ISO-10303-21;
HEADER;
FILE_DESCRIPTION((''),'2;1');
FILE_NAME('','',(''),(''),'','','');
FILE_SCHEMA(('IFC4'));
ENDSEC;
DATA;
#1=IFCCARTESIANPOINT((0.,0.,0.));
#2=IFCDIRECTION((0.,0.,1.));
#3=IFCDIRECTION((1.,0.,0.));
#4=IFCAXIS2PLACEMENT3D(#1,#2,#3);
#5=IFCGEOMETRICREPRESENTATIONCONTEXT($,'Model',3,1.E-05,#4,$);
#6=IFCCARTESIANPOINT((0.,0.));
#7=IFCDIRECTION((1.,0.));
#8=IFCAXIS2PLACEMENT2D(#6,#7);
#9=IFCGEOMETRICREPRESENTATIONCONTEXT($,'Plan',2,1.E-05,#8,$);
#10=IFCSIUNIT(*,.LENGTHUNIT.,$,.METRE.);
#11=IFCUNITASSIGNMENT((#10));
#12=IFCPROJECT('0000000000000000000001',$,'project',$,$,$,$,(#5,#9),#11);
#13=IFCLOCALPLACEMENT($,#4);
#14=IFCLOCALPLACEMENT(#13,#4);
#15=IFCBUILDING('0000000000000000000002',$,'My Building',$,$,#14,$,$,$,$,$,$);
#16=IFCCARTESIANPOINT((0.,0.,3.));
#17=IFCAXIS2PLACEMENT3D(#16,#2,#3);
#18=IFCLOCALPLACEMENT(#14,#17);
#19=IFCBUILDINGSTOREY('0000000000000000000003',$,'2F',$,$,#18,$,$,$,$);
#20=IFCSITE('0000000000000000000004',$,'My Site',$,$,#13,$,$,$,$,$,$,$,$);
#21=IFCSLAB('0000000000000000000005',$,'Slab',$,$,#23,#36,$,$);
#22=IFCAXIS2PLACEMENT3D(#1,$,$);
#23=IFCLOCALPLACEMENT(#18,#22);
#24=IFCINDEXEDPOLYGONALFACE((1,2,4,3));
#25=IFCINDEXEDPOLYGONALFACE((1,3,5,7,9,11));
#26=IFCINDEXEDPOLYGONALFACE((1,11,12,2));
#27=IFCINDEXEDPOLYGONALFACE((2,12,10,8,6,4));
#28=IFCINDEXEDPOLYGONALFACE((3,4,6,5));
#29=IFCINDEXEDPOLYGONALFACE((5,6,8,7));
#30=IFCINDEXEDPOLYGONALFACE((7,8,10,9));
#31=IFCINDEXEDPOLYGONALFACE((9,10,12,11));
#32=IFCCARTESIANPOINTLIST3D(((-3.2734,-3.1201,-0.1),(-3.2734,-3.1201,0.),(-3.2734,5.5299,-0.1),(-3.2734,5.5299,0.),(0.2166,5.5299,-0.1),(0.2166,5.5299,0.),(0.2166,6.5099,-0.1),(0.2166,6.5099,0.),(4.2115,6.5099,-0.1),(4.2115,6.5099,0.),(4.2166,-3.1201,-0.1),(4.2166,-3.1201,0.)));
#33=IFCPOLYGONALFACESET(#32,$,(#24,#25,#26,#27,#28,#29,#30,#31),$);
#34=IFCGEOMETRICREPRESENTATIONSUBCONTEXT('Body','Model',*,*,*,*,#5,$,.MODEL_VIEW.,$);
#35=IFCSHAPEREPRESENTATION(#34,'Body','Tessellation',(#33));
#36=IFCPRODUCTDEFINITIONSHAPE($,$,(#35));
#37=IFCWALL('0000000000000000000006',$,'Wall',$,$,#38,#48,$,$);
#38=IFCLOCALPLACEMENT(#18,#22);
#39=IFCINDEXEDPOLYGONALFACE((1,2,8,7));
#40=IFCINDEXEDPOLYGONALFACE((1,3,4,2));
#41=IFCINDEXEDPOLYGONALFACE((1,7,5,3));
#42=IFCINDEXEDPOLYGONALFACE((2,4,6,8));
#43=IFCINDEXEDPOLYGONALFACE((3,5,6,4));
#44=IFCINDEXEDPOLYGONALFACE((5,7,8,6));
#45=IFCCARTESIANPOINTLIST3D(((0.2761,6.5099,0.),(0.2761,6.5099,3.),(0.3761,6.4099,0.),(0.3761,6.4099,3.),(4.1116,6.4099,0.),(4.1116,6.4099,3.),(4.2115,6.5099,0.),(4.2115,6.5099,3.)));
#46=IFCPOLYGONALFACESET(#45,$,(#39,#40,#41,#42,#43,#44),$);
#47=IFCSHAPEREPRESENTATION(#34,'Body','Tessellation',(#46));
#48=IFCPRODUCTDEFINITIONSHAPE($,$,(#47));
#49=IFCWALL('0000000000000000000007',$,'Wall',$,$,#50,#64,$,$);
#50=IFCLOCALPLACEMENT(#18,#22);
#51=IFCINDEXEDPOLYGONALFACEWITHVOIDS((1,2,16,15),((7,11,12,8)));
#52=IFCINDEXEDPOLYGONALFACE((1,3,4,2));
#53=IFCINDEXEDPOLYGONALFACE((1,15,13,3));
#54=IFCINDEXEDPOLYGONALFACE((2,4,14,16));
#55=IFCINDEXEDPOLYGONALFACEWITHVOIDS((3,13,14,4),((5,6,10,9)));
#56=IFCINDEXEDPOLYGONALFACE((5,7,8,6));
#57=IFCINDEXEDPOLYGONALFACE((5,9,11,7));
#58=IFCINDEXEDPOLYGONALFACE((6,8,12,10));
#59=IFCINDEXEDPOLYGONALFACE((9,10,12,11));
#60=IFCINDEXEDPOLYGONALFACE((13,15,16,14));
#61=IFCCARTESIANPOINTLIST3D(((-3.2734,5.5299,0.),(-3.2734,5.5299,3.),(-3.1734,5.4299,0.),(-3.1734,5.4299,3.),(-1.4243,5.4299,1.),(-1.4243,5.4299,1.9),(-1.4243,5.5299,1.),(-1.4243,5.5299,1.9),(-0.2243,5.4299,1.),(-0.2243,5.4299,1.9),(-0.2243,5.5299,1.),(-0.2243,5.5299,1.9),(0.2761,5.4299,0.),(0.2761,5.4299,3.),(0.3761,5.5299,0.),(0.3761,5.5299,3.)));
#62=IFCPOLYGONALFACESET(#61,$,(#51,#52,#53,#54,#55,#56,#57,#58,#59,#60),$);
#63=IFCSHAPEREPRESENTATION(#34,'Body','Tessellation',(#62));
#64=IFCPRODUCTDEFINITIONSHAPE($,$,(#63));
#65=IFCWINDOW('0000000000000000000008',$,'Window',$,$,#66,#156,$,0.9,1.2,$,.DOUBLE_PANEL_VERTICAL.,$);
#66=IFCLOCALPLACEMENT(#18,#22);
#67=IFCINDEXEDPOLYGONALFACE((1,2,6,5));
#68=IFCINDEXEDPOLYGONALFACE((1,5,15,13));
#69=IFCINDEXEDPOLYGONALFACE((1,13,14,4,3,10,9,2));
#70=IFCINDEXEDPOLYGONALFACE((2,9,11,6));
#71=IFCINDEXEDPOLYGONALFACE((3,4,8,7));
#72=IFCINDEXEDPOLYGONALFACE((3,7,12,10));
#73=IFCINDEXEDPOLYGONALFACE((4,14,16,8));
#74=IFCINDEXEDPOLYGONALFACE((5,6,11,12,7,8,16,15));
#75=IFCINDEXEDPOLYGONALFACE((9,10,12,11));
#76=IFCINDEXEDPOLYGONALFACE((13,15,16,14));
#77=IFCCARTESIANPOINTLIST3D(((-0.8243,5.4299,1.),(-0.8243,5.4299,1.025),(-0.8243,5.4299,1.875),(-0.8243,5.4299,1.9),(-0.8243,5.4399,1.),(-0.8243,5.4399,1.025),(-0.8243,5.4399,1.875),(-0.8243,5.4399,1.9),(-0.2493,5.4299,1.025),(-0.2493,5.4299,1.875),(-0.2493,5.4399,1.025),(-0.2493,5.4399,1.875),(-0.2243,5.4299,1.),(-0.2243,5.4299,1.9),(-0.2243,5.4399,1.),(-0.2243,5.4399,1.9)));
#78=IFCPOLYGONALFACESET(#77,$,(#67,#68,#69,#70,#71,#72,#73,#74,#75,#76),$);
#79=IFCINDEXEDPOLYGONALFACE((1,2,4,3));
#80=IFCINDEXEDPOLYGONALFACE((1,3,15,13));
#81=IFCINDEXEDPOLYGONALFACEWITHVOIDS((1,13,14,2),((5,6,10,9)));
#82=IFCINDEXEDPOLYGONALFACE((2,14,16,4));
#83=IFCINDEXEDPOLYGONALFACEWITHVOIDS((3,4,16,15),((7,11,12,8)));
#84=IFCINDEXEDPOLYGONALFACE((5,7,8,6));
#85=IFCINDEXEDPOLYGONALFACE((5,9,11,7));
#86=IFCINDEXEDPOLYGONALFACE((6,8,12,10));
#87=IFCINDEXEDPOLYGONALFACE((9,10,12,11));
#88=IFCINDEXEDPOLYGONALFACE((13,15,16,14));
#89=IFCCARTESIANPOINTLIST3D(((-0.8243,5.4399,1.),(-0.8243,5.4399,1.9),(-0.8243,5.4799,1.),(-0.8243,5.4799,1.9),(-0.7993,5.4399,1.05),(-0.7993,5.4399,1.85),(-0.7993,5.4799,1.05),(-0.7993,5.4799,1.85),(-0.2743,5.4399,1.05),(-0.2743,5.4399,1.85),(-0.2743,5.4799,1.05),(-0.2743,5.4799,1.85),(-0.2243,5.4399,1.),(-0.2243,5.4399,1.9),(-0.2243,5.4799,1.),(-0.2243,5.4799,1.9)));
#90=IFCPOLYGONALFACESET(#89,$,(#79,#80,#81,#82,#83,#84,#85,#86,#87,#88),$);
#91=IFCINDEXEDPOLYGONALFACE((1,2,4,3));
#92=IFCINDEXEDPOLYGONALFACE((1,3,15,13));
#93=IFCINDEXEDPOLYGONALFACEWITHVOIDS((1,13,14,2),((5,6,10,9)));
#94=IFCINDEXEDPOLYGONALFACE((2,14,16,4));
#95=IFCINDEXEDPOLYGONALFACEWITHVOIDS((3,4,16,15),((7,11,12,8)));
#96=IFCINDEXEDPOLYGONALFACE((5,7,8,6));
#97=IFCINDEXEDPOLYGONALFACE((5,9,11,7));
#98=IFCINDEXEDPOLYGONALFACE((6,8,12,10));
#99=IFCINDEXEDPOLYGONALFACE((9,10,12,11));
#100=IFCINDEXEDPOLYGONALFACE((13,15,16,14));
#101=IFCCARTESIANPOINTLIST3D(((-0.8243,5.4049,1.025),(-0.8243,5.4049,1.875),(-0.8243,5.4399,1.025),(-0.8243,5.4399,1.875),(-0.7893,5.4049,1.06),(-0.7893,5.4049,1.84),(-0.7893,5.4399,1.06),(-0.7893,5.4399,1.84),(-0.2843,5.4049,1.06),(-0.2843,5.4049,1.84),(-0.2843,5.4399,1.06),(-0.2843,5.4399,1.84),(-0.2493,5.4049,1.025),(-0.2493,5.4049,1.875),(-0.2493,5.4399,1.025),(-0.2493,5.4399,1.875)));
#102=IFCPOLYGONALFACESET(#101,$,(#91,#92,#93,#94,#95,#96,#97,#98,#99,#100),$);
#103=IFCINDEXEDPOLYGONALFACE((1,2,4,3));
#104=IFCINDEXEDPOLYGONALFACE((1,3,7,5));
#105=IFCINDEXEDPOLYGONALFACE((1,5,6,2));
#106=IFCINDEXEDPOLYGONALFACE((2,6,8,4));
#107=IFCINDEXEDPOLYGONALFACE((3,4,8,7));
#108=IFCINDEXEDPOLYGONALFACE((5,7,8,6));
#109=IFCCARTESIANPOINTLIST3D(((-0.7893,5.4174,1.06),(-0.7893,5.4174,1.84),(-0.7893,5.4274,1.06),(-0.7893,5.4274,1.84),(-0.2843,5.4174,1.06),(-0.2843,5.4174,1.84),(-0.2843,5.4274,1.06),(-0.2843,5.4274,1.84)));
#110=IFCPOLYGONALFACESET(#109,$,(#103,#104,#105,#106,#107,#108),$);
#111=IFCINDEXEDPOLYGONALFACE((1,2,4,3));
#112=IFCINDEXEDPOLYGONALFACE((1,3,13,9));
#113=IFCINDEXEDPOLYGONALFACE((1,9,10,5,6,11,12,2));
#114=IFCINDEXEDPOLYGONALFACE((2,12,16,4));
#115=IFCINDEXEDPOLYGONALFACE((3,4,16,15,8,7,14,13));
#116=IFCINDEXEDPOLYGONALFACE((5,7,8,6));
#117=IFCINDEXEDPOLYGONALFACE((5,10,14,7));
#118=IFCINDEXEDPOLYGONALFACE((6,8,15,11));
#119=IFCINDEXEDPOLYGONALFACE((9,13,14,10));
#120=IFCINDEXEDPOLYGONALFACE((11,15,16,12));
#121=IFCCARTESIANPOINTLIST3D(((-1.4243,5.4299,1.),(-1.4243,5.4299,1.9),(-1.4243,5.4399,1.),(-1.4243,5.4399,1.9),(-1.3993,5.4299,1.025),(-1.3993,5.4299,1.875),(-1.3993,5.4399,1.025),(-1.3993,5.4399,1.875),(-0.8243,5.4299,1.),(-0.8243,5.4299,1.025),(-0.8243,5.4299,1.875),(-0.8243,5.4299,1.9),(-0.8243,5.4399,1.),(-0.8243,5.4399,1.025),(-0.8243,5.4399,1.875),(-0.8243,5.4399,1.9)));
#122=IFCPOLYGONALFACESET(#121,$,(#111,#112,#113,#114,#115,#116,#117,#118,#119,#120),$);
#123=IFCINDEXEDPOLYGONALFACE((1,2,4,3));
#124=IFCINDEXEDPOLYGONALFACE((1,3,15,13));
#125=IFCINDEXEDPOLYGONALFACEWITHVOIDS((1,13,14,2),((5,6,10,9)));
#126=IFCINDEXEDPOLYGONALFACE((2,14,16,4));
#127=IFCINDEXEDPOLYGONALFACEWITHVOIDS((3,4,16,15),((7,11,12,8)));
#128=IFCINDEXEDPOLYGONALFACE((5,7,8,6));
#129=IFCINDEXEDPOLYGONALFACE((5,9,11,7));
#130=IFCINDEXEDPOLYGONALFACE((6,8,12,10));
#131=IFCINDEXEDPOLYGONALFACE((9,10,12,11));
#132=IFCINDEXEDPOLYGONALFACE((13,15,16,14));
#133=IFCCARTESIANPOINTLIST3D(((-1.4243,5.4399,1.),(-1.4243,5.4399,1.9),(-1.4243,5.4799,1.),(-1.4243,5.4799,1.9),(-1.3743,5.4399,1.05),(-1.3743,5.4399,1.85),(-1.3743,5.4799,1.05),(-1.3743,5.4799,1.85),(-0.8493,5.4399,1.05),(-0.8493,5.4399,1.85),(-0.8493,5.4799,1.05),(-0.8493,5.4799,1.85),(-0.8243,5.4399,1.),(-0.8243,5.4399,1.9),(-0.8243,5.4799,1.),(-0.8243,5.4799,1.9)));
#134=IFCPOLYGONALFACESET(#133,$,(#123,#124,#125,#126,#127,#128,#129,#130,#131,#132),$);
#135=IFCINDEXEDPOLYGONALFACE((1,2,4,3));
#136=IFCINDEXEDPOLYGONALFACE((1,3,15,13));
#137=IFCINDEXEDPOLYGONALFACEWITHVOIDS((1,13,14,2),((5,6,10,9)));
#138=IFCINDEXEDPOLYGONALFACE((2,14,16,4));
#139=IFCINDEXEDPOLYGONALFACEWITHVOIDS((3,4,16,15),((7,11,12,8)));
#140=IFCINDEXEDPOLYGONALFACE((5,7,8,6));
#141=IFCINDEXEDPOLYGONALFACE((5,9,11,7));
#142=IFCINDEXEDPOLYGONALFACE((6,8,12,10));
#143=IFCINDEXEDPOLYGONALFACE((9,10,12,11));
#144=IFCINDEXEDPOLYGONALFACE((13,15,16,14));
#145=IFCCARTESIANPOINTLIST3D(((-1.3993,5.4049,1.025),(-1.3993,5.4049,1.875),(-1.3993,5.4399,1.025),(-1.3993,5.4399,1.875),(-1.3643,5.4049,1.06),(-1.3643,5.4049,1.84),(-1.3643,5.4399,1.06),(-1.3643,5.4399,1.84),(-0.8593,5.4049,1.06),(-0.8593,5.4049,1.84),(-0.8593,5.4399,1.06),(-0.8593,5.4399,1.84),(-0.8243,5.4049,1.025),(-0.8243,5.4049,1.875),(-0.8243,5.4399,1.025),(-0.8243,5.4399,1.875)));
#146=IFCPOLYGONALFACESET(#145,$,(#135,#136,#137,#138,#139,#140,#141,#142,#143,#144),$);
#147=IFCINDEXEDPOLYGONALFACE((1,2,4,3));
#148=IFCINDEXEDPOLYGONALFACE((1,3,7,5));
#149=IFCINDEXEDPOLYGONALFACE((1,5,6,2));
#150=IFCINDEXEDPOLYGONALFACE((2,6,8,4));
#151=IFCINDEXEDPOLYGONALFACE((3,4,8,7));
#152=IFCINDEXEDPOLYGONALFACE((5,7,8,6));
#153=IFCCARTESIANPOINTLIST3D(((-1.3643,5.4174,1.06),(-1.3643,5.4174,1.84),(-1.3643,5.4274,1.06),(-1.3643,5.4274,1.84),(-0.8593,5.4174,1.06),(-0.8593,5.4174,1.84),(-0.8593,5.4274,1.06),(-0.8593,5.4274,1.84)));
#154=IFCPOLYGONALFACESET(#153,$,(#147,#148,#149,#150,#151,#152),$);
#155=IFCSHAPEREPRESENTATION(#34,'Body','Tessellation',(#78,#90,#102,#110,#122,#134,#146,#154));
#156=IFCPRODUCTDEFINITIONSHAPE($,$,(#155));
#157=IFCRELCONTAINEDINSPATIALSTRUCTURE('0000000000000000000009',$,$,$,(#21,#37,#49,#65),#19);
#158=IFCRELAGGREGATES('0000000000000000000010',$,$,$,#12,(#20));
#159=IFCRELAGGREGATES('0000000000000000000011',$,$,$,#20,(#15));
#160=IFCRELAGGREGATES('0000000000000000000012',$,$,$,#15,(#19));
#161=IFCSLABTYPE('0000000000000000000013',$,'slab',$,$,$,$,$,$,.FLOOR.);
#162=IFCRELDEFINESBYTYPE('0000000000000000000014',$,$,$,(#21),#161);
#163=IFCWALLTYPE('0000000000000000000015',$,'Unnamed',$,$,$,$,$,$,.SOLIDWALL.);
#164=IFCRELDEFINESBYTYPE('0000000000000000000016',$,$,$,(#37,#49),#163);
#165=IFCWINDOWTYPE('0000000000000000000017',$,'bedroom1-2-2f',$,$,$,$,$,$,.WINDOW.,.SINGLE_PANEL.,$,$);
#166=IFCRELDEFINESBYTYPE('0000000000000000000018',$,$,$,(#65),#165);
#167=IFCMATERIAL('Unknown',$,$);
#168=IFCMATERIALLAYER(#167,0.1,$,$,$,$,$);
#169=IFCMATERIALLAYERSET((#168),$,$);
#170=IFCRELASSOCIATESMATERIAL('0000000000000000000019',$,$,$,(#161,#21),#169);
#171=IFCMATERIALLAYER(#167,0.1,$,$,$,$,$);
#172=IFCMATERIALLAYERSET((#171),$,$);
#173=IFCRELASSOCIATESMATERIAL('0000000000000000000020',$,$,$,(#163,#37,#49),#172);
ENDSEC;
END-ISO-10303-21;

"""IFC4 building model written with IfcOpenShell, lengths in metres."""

from ifc_helpers import new_model, entity, si_unit, frame, origin_with_axes, origin_2d_with_axis, place, context, subcontext, project, spatial, line, indexed_curve, outline, extrude, shape, source, transform, mapped, material, layer, layer_set, layer_usage, type_object, type_shapes, element, fill, save


model = new_model("IFC4")

# Units and contexts
model_context = context("Model", 3, precision=1e-05, world=origin_with_axes())
plan_context = context("Plan", 2, precision=1e-05, world=origin_2d_with_axis())
body_context_1 = subcontext(model_context, "Body", "Model", "MODEL_VIEW")
body_context_2 = subcontext(plan_context, "Body", "Plan", "PLAN_VIEW")
ifc_project = project(units=[si_unit("LENGTHUNIT", "METRE")], contexts=[model_context, plan_context])

# Site, building, storey
site_placement = place(None, origin_with_axes())
site = spatial("IfcSite", under=ifc_project, at=site_placement, Name="My Site")
building_placement = place(site_placement, origin_with_axes())
building = spatial("IfcBuilding", under=site, at=building_placement, Name="My Building")
storey_placement = place(building_placement, frame((0.0, 0.0, 3.0), z_axis=(0.0, 0.0, 1.0), x_axis=(1.0, 0.0, 0.0)))
storey = spatial("IfcBuildingStorey", under=building, at=storey_placement, Name="2F")

# Slab
ifc_material = material(Name="Unknown")
ifc_layer_1 = layer(ifc_material, 0.1)
ifc_layer_set_1 = layer_set([ifc_layer_1])
ifc_layer_usage_1 = layer_usage(ifc_layer_set_1, "AXIS3", "POSITIVE", -0.1)
slab_type = type_object("IfcSlabType", Name="slab", PredefinedType="FLOOR", material=ifc_layer_set_1)
slab_placement = place(storey_placement, frame((4.2115, 6.5099, 0.0), z_axis=(0.0, 0.0, 1.0), x_axis=(1.0, 0.0, 0.0)))
element("IfcSlab", 1, at=slab_placement, inside=storey, type_object=slab_type, material=ifc_layer_usage_1, Name="Slab", context=body_context_1, shape_type="SweptSolid", body=[
    extrude(outline(indexed_curve([(0.0, 0.0), (-3.9949, 0.0), (-3.9949, -0.98), (-7.4849, -0.98), (-7.4849, -9.63), (0.0051, -9.63), (0.0, 0.0)])), frame((0.0, 0.0, -0.1), z_axis=(0.0, 0.0, 1.0), x_axis=(1.0, 0.0, 0.0)), (0.0, 0.0, 1.0), 0.1),
])

# Wall
ifc_layer_2 = layer(ifc_material, 0.1)
ifc_layer_set_2 = layer_set([ifc_layer_2])
ifc_layer_usage_2 = layer_usage(ifc_layer_set_2, "AXIS2", "POSITIVE", 0.0)
wall_type = type_object("IfcWallType", Name="Unnamed", PredefinedType="SOLIDWALL", material=ifc_layer_set_2)
wall_1_placement = place(storey_placement, frame((4.2115, 6.5099, 0.0), z_axis=(0.0, 0.0, 1.0), x_axis=(-1.0, 0.0, 0.0)))
element("IfcWall", 2, at=wall_1_placement, inside=storey, type_object=wall_type, material=ifc_layer_usage_2, Name="Wall", context=body_context_1, shape_type="SweptSolid", body=[
    extrude(outline(indexed_curve([(0.0, 0.0), (0.1, 0.1), (3.8355, 0.1), (3.9355, 0.0)], segments=[line(1, 2, 3, 4, 1)])), origin_with_axes(), (0.0, 0.0, 1.0), 3.0),
])

# Wall, opening, window
ifc_layer_usage_3 = layer_usage(ifc_layer_set_2, "AXIS2", "POSITIVE", 0.0)
wall_2_placement = place(storey_placement, frame((0.3761, 5.5299, 0.0), z_axis=(0.0, 0.0, 1.0), x_axis=(-1.0, 0.0, 0.0)))
wall_2 = element("IfcWall", 3, at=wall_2_placement, inside=storey, type_object=wall_type, material=ifc_layer_usage_3, Name="Wall", context=body_context_1, shape_type="SweptSolid", body=[
    extrude(outline(indexed_curve([(0.0, 0.0), (0.1, 0.1), (3.5495, 0.1), (3.6495, 0.0)], segments=[line(1, 2, 3, 4, 1)])), origin_with_axes(), (0.0, 0.0, 1.0), 3.0),
])
shared_shape_1 = source(origin_with_axes(), body_context_1, "Body", "SweptSolid", [
    extrude(outline(indexed_curve([(0.0, 0.0), (1.2, 0.0), (1.2, 0.9), (0.0, 0.9)], segments=[line(1, 2, 3, 4, 1)])), frame((0.0, -0.6, 0.0), z_axis=(0.0, -1.0, 0.0), x_axis=(1.0, 0.0, 0.0)), (0.0, 0.0, -1.0), 1.2),
])
opening_1_placement = place(wall_2_placement, frame((0.6003, 0.0, 1.0), z_axis=(0.0, 0.0, 1.0), x_axis=(1.0, 0.0, 0.0)))
opening_1 = element("IfcOpeningElement", 4, at=opening_1_placement, cuts=wall_2, PredefinedType="OPENING", context=body_context_1, shape_type="MappedRepresentation", body=[
    mapped(shared_shape_1, transform((0.0, 0.0, 0.0), x_axis=(1.0, 0.0, 0.0), y_axis=(0.0, 1.0, 0.0), z_axis=(0.0, 0.0, 1.0), scale=1.0)),
])
window_type_1 = type_object("IfcWindowType", Name="bedroom1-2-2f", PartitioningType="SINGLE_PANEL", PredefinedType="WINDOW")
shared_shape_2 = source(origin_with_axes(), body_context_1, "Body", "SweptSolid", [
    extrude(outline(indexed_curve([(0.6, 0.0), (0.0, 0.0), (0.0, 0.9), (0.6, 0.9), (0.6, 0.875), (0.025, 0.875), (0.025, 0.025), (0.6, 0.025)], segments=[line(1, 2, 3, 4, 5, 6, 7, 8, 1)])), frame((0.0, 0.09, 0.0), z_axis=(0.0, -1.0, 0.0), x_axis=(1.0, 0.0, 0.0)), (0.0, 0.0, -1.0), 0.01),
    extrude(outline(indexed_curve([(0.0, 0.0), (0.6, 0.0), (0.6, 0.9), (0.0, 0.9)], segments=[line(1, 2, 3, 4, 1)]), holes=[indexed_curve([(0.05, 0.05), (0.575, 0.05), (0.575, 0.85), (0.05, 0.85)], segments=[line(1, 2, 3, 4, 1)])]), frame((0.0, 0.05, 0.0), z_axis=(0.0, -1.0, 0.0), x_axis=(1.0, 0.0, 0.0)), (0.0, 0.0, -1.0), 0.04),
    extrude(outline(indexed_curve([(0.0, 0.0), (0.575, 0.0), (0.575, 0.85), (0.0, 0.85)], segments=[line(1, 2, 3, 4, 1)]), holes=[indexed_curve([(0.035, 0.035), (0.54, 0.035), (0.54, 0.815), (0.035, 0.815)], segments=[line(1, 2, 3, 4, 1)])]), frame((0.025, 0.09, 0.025), z_axis=(0.0, -1.0, 0.0), x_axis=(1.0, 0.0, 0.0)), (0.0, 0.0, -1.0), 0.035),
    extrude(outline(indexed_curve([(0.035, 0.035), (0.54, 0.035), (0.54, 0.815), (0.035, 0.815)], segments=[line(1, 2, 3, 4, 1)])), frame((0.025, 0.1025, 0.025), z_axis=(0.0, -1.0, 0.0), x_axis=(1.0, 0.0, 0.0)), (0.0, 0.0, -1.0), 0.01),
    extrude(outline(indexed_curve([(0.0, 0.9), (0.6, 0.9), (0.6, 0.0), (0.0, 0.0), (0.0, 0.025), (0.575, 0.025), (0.575, 0.875), (0.0, 0.875)], segments=[line(1, 2, 3, 4, 5, 6, 7, 8, 1)])), frame((0.6, 0.09, 0.0), z_axis=(0.0, -1.0, 0.0), x_axis=(1.0, 0.0, 0.0)), (0.0, 0.0, -1.0), 0.01),
    extrude(outline(indexed_curve([(0.0, 0.0), (0.6, 0.0), (0.6, 0.9), (0.0, 0.9)], segments=[line(1, 2, 3, 4, 1)]), holes=[indexed_curve([(0.025, 0.05), (0.55, 0.05), (0.55, 0.85), (0.025, 0.85)], segments=[line(1, 2, 3, 4, 1)])]), frame((0.6, 0.05, 0.0), z_axis=(0.0, -1.0, 0.0), x_axis=(1.0, 0.0, 0.0)), (0.0, 0.0, -1.0), 0.04),
    extrude(outline(indexed_curve([(0.0, 0.0), (0.575, 0.0), (0.575, 0.85), (0.0, 0.85)], segments=[line(1, 2, 3, 4, 1)]), holes=[indexed_curve([(0.035, 0.035), (0.54, 0.035), (0.54, 0.815), (0.035, 0.815)], segments=[line(1, 2, 3, 4, 1)])]), frame((0.6, 0.09, 0.025), z_axis=(0.0, -1.0, 0.0), x_axis=(1.0, 0.0, 0.0)), (0.0, 0.0, -1.0), 0.035),
    extrude(outline(indexed_curve([(0.035, 0.035), (0.54, 0.035), (0.54, 0.815), (0.035, 0.815)], segments=[line(1, 2, 3, 4, 1)])), frame((0.6, 0.1025, 0.025), z_axis=(0.0, -1.0, 0.0), x_axis=(1.0, 0.0, 0.0)), (0.0, 0.0, -1.0), 0.01),
])
shared_shape_3 = source(origin_with_axes(), body_context_2, "Body", "Curve2D", [
    entity("IfcIndexedPolyCurve", entity("IfcCartesianPointList2D", [[0.05, 0.05], [0.575, 0.05]])),
    entity("IfcIndexedPolyCurve", entity("IfcCartesianPointList2D", [[0.0, 0.1], [0.025, 0.1], [0.025, 0.09], [0.05, 0.09], [0.05, 0.05], [0.0, 0.05]]), [entity("IfcLineIndex", [1, 2, 3, 4, 5, 6, 1])]),
    entity("IfcIndexedPolyCurve", entity("IfcCartesianPointList2D", [[0.6, 0.1], [0.6, 0.1], [0.6, 0.09], [0.575, 0.09], [0.575, 0.05], [0.6, 0.05]])),
    entity("IfcIndexedPolyCurve", entity("IfcCartesianPointList2D", [[0.025, 0.09], [0.06, 0.09], [0.06, 0.125], [0.025, 0.125]]), [entity("IfcLineIndex", [1, 2, 3, 4, 1])]),
    entity("IfcIndexedPolyCurve", entity("IfcCartesianPointList2D", [[0.6, 0.09], [0.565, 0.09], [0.565, 0.125], [0.6, 0.125]]), [entity("IfcLineIndex", [1, 2, 3, 4, 1])]),
    entity("IfcIndexedPolyCurve", entity("IfcCartesianPointList2D", [[0.06, 0.09], [0.565, 0.09]])),
    entity("IfcIndexedPolyCurve", entity("IfcCartesianPointList2D", [[0.06, 0.125], [0.565, 0.125]])),
    entity("IfcIndexedPolyCurve", entity("IfcCartesianPointList2D", [[0.06, 0.1075], [0.565, 0.1075]])),
    entity("IfcIndexedPolyCurve", entity("IfcCartesianPointList2D", [[0.625, 0.05], [1.15, 0.05]])),
    entity("IfcIndexedPolyCurve", entity("IfcCartesianPointList2D", [[0.6, 0.1], [0.6, 0.1], [0.6, 0.09], [0.625, 0.09], [0.625, 0.05], [0.6, 0.05]])),
    entity("IfcIndexedPolyCurve", entity("IfcCartesianPointList2D", [[1.2, 0.1], [1.175, 0.1], [1.175, 0.09], [1.15, 0.09], [1.15, 0.05], [1.2, 0.05]]), [entity("IfcLineIndex", [1, 2, 3, 4, 5, 6, 1])]),
    entity("IfcIndexedPolyCurve", entity("IfcCartesianPointList2D", [[0.6, 0.09], [0.635, 0.09], [0.635, 0.125], [0.6, 0.125]]), [entity("IfcLineIndex", [1, 2, 3, 4, 1])]),
    entity("IfcIndexedPolyCurve", entity("IfcCartesianPointList2D", [[1.175, 0.09], [1.14, 0.09], [1.14, 0.125], [1.175, 0.125]]), [entity("IfcLineIndex", [1, 2, 3, 4, 1])]),
    entity("IfcIndexedPolyCurve", entity("IfcCartesianPointList2D", [[0.635, 0.09], [1.14, 0.09]])),
    entity("IfcIndexedPolyCurve", entity("IfcCartesianPointList2D", [[0.635, 0.125], [1.14, 0.125]])),
    entity("IfcIndexedPolyCurve", entity("IfcCartesianPointList2D", [[0.635, 0.1075], [1.14, 0.1075]])),
])
type_shapes(window_type_1, [shared_shape_2, shared_shape_3])
window_1_placement = place(opening_1_placement, frame((0.0, 0.0, 0.0), z_axis=(0.0, 0.0, 1.0), x_axis=(1.0, 0.0, 0.0)))
window_1 = element("IfcWindow", 5, at=window_1_placement, inside=storey, type_object=window_type_1, Name="Window", OverallHeight=0.9, OverallWidth=1.2, PartitioningType="DOUBLE_PANEL_VERTICAL", shapes=[
    shape(body_context_1, "Body", "MappedRepresentation", [mapped(shared_shape_2, transform((0.0, 0.0, 0.0), x_axis=(1.0, 0.0, 0.0), y_axis=(0.0, 1.0, 0.0), z_axis=(0.0, 0.0, 1.0), scale=1.0))]),
    shape(body_context_2, "Body", "MappedRepresentation", [mapped(shared_shape_3, transform((0.0, 0.0, 0.0), x_axis=(1.0, 0.0, 0.0), y_axis=(0.0, 1.0, 0.0), z_axis=(0.0, 0.0, 1.0), scale=1.0))]),
])
fill(opening_1, window_1)

save(model, "model.ifc")
